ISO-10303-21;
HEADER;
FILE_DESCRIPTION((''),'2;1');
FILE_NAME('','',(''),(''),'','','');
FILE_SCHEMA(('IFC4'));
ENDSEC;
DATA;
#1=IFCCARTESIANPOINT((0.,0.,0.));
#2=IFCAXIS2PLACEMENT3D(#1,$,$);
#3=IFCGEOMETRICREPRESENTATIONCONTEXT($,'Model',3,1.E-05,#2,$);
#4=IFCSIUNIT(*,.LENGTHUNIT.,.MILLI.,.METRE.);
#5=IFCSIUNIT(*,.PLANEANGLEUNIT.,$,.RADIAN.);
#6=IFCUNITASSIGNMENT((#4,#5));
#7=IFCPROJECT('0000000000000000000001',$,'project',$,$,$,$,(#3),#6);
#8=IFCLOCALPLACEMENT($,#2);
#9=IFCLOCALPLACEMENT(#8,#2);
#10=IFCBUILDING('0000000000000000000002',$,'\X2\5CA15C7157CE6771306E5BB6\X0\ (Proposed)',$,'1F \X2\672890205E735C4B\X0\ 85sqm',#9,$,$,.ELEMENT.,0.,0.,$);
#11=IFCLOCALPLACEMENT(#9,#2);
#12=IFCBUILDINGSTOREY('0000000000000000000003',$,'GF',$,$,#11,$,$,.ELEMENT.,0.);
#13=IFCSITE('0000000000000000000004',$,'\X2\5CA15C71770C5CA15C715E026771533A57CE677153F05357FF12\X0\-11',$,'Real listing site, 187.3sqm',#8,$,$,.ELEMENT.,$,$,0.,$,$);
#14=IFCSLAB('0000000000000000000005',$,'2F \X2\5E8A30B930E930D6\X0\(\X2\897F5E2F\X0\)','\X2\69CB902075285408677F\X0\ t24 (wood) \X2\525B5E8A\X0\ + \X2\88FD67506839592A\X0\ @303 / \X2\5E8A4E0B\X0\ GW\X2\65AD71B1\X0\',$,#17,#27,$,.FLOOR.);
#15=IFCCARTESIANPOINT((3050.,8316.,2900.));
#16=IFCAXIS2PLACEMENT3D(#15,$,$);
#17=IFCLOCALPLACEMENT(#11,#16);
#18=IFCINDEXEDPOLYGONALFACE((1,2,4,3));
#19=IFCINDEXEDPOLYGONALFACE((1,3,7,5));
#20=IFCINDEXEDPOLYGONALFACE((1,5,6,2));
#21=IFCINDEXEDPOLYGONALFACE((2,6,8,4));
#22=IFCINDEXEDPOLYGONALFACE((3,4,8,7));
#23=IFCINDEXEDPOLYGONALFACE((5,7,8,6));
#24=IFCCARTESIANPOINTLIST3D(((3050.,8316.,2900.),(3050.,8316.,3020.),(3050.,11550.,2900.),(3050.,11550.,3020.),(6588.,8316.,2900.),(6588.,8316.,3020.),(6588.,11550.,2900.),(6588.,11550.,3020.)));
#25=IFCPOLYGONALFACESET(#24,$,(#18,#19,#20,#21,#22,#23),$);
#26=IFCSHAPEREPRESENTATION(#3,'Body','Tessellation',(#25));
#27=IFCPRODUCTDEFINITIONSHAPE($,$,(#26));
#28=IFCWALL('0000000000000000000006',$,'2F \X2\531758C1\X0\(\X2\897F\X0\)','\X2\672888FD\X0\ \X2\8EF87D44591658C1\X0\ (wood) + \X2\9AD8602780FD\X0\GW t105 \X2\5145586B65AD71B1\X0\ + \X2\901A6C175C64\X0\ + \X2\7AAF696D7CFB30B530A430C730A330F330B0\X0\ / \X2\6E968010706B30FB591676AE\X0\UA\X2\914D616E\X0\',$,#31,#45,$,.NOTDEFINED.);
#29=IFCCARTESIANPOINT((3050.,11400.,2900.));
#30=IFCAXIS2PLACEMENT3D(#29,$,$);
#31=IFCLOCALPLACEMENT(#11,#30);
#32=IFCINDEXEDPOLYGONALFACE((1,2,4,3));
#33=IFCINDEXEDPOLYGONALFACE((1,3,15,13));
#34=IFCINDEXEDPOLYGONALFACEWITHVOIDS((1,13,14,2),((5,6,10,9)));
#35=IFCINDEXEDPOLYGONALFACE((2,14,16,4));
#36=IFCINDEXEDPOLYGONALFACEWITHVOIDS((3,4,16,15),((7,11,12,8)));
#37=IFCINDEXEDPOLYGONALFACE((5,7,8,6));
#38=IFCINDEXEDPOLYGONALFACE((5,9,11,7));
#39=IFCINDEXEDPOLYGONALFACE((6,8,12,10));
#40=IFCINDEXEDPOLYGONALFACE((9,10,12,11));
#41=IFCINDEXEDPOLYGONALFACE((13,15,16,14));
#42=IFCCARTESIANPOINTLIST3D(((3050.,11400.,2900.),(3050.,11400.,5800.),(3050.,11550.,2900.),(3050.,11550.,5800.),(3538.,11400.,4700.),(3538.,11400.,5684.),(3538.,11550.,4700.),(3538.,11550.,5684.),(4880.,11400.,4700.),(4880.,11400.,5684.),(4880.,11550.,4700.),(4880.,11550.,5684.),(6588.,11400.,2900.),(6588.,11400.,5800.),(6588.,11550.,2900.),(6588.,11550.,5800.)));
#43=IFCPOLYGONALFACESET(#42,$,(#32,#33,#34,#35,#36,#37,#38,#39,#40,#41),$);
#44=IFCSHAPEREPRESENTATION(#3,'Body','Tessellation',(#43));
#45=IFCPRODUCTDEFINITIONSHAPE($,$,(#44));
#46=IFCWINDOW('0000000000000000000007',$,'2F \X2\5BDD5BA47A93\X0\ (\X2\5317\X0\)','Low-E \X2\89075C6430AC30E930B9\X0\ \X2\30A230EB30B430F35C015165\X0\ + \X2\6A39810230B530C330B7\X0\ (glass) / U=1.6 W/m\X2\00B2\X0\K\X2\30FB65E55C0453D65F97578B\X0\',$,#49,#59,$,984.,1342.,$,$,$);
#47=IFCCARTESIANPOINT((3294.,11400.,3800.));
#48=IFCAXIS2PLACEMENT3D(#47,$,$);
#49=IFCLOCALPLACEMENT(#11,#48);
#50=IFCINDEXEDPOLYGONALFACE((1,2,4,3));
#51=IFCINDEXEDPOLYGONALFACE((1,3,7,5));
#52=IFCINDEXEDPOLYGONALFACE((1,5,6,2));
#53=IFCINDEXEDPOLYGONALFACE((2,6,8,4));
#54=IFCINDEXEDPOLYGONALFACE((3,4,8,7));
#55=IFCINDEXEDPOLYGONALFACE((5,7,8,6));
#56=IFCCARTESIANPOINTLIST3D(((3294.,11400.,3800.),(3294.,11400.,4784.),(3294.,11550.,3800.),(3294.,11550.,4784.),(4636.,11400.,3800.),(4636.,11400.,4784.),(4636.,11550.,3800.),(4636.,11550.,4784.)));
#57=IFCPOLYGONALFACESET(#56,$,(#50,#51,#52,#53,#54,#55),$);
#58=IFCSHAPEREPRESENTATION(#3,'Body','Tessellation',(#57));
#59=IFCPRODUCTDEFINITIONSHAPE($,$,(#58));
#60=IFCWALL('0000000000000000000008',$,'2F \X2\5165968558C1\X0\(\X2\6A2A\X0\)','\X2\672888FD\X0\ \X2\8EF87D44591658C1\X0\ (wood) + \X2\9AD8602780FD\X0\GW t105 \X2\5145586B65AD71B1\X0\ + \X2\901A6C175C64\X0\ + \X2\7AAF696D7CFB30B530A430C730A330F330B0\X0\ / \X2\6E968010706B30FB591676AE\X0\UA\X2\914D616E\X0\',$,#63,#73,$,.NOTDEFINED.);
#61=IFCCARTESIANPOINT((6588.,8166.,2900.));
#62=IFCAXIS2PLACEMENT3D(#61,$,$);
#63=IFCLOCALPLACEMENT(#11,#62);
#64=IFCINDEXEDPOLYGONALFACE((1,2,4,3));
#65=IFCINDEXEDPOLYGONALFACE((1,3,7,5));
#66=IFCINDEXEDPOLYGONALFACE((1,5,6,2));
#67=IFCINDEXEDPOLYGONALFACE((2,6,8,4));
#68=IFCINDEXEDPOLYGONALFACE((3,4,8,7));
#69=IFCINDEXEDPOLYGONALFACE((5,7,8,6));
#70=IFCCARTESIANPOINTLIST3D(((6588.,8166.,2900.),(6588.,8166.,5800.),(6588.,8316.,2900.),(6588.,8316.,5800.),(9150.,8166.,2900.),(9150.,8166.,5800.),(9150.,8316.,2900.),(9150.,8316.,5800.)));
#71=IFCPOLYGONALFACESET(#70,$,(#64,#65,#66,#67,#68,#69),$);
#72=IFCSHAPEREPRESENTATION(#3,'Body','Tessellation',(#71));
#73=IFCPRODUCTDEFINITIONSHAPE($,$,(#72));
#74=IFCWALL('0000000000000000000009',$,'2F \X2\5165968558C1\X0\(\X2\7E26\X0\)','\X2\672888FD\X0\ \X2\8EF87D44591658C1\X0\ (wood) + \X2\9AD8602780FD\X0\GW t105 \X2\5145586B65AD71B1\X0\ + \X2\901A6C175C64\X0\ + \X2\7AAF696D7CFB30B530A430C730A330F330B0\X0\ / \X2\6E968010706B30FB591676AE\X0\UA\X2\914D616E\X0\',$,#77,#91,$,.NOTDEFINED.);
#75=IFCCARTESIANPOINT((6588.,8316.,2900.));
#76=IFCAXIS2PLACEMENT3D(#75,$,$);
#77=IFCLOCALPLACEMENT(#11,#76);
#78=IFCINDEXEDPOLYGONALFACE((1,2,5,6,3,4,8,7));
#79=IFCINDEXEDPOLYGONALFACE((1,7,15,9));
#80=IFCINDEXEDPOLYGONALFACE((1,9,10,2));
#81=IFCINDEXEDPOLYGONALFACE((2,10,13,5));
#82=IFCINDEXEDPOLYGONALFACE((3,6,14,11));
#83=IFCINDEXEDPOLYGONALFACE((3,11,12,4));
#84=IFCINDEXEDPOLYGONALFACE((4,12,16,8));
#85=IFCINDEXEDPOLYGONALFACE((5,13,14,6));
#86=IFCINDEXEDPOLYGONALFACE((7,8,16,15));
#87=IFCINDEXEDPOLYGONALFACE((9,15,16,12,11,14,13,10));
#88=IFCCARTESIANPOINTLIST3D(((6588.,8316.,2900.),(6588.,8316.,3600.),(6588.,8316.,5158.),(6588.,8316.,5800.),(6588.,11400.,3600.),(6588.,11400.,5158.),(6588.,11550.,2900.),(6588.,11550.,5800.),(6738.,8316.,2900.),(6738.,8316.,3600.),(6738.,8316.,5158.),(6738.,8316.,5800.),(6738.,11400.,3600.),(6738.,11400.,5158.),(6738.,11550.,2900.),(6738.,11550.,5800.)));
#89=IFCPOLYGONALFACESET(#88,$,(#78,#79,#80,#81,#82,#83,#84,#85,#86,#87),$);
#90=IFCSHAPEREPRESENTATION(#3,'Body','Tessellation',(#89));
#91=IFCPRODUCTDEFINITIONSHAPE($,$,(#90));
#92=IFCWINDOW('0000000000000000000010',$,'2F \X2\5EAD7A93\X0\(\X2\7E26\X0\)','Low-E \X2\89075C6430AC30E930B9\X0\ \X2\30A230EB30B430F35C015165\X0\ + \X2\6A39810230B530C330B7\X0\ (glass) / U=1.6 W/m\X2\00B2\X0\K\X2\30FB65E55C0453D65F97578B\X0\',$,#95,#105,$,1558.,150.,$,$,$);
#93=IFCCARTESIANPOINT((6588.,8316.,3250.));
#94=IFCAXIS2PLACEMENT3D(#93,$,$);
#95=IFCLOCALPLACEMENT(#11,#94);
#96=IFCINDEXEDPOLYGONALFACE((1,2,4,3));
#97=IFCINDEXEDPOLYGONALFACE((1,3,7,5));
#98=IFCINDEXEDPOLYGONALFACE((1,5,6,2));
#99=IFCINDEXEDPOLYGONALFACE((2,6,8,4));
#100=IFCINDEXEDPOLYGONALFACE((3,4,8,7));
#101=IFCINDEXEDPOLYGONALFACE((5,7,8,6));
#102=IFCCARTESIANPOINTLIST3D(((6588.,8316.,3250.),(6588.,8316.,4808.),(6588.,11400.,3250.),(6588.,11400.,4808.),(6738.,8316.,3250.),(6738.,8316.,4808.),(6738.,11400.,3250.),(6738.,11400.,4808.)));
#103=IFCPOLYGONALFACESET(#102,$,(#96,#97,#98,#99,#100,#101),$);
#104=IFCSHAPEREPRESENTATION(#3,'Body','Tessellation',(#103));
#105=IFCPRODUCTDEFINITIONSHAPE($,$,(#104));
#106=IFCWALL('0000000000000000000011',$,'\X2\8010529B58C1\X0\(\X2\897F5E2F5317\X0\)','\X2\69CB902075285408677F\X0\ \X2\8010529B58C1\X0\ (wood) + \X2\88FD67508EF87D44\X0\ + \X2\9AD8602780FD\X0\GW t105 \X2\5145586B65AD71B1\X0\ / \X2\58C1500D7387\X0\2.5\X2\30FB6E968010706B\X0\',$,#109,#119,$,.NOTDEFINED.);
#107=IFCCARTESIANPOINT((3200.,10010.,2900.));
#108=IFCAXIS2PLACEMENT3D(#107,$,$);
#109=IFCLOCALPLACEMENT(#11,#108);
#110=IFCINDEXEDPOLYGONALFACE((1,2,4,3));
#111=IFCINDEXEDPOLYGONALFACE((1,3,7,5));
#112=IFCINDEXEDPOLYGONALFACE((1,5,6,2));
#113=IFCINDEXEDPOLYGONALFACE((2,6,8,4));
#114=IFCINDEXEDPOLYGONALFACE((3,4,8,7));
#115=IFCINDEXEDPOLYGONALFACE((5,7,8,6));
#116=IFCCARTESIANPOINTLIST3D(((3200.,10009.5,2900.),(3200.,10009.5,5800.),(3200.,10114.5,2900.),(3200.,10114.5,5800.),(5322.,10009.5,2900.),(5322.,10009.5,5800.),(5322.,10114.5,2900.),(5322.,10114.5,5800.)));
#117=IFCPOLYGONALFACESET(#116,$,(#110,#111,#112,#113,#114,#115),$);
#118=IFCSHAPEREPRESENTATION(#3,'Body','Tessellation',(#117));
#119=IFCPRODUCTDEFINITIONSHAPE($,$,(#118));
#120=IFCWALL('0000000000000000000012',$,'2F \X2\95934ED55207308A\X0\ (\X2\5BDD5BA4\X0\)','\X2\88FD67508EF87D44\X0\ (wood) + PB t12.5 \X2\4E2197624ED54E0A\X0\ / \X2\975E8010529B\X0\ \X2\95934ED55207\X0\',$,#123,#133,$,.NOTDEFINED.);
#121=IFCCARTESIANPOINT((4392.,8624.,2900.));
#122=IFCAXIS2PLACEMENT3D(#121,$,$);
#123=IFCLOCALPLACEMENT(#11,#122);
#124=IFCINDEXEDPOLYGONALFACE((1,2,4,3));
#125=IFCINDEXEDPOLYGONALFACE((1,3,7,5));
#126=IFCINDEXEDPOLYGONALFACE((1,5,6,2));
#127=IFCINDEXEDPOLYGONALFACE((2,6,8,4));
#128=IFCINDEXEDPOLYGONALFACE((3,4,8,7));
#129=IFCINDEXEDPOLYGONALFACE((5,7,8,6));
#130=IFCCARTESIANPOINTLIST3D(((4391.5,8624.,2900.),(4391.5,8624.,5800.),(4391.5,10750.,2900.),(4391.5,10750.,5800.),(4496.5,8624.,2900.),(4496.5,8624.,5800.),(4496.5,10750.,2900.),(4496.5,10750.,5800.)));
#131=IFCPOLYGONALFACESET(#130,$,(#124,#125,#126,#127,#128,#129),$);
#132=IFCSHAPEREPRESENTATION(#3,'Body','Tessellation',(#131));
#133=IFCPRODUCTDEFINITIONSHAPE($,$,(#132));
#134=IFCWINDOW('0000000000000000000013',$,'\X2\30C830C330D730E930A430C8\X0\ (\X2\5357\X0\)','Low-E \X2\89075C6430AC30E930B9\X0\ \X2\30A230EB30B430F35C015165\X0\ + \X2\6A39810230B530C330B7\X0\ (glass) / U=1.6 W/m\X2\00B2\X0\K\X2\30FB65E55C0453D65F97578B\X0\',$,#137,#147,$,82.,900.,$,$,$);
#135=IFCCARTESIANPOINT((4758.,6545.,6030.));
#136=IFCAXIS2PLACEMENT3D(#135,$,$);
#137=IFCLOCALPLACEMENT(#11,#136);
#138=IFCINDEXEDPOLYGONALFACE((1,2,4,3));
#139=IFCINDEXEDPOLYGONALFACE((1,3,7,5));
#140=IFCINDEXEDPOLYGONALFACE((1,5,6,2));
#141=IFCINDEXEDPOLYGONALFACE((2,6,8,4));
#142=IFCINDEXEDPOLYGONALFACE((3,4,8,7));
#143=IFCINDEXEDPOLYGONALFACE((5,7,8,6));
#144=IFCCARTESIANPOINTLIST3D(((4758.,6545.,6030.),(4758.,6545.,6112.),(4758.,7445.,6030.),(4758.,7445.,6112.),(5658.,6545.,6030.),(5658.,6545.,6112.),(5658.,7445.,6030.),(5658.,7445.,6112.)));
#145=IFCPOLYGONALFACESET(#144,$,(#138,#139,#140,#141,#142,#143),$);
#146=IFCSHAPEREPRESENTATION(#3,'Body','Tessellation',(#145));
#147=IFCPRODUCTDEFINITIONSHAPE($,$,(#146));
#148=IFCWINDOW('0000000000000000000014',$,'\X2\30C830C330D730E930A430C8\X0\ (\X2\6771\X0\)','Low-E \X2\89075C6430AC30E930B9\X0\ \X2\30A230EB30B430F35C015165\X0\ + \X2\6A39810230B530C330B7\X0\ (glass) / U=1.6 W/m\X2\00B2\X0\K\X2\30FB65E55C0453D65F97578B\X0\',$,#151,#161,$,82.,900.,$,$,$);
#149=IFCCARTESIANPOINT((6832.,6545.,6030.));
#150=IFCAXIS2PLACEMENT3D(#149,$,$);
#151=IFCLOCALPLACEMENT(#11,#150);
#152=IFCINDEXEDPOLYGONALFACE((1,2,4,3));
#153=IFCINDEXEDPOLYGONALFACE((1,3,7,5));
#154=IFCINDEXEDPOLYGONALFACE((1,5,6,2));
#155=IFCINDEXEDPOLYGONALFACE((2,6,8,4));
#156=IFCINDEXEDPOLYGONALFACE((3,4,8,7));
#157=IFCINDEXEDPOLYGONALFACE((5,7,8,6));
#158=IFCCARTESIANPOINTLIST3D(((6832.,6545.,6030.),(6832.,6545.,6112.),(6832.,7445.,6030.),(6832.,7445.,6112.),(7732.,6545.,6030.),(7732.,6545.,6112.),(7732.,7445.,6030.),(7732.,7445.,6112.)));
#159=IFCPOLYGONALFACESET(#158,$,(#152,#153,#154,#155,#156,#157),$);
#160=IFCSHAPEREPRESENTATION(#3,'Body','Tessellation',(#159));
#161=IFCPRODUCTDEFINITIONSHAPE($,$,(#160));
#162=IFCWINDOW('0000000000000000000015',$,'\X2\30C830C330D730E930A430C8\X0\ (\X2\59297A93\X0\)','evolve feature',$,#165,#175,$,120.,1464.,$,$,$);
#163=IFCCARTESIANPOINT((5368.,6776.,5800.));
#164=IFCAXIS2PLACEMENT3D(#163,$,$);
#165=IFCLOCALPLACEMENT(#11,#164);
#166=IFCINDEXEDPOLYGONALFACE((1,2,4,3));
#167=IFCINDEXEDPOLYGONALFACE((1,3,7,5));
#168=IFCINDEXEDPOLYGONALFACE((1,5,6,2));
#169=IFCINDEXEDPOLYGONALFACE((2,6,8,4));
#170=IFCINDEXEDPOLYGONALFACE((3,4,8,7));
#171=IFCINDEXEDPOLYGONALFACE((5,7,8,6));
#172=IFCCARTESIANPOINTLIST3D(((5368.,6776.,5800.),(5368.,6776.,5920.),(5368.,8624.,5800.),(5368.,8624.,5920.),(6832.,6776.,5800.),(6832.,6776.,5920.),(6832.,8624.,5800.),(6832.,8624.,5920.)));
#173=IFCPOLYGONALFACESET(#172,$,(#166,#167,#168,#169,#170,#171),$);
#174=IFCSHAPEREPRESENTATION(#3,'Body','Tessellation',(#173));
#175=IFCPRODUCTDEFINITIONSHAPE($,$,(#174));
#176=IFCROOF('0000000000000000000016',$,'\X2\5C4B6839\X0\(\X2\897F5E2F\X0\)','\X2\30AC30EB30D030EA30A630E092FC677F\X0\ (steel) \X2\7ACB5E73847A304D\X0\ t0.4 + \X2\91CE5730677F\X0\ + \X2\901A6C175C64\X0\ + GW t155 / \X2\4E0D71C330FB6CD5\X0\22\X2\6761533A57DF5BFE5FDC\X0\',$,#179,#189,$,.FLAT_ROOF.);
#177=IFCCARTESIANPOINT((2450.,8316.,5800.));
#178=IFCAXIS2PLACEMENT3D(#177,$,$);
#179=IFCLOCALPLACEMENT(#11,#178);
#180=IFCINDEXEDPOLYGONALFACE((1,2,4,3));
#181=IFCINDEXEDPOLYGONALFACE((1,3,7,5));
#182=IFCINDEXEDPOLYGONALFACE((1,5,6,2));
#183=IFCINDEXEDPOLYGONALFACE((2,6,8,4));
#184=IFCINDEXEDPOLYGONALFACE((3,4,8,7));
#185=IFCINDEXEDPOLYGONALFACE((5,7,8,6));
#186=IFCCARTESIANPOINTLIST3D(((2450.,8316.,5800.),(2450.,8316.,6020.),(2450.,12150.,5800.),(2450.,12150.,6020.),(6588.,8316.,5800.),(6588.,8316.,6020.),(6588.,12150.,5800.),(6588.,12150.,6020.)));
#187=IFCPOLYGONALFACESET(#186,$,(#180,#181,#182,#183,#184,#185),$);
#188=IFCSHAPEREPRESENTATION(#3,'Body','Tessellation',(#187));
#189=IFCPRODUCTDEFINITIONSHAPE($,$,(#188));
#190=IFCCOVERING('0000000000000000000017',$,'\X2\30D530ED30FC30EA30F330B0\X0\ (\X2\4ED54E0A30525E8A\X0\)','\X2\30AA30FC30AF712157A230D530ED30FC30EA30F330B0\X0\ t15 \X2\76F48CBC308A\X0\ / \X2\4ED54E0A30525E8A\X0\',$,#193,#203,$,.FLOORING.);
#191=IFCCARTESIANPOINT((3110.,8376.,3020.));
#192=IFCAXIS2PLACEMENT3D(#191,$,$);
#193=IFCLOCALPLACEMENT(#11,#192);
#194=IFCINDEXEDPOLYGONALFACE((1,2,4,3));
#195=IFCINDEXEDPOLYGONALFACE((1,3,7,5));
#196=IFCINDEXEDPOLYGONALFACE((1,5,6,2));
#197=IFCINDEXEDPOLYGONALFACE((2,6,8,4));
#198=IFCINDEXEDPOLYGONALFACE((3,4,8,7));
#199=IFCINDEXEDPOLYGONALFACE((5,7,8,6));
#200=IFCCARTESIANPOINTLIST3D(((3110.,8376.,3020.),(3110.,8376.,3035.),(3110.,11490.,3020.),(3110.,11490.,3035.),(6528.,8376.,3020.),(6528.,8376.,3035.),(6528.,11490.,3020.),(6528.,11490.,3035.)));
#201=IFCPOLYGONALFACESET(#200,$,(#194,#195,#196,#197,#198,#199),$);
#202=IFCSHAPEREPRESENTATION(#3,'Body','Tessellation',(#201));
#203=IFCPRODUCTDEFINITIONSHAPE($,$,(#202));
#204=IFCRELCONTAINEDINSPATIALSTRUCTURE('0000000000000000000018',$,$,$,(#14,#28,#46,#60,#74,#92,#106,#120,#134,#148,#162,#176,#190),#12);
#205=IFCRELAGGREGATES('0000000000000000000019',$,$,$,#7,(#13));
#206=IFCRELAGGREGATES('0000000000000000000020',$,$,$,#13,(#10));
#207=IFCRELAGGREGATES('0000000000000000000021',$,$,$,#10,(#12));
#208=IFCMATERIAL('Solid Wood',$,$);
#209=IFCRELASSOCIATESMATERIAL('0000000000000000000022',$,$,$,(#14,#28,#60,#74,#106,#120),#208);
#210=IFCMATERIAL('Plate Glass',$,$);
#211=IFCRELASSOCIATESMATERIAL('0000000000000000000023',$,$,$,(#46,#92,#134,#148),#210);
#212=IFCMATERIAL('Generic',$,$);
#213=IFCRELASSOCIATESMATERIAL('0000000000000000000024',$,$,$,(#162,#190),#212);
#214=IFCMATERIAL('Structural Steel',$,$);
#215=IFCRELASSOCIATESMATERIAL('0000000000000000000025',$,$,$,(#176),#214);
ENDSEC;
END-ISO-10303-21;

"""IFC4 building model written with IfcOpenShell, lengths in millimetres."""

from ifc_helpers import new_model, si_unit, frame, frame_2d, origin, place, context, project, spatial, rectangle, extrude, material, element, fill, save


model = new_model("IFC4")

# Units and contexts
model_context = context("Model", 3, precision=1e-05, world=origin())
ifc_project = project(units=[si_unit("LENGTHUNIT", "METRE", prefix="MILLI"), si_unit("PLANEANGLEUNIT", "RADIAN")], contexts=[model_context])

# Site, building, storey
site_placement = place(None, origin())
site = spatial("IfcSite", under=ifc_project, at=site_placement, Name="岡山県岡山市東区城東台南２-11", ObjectType="Real listing site, 187.3sqm", CompositionType="ELEMENT", RefElevation=0.0)
building_placement = place(site_placement, origin())
building = spatial("IfcBuilding", under=site, at=building_placement, Name="岡山城東の家 (Proposed)", ObjectType="1F 木造平屋 85sqm", CompositionType="ELEMENT", ElevationOfRefHeight=0.0, ElevationOfTerrain=0.0)
storey_placement = place(building_placement, origin())
storey = spatial("IfcBuildingStorey", under=building, at=storey_placement, Name="GF", CompositionType="ELEMENT", Elevation=0.0)

# Slab
ifc_material_1 = material(Name="Solid Wood")
slab_placement = place(storey_placement, frame((3050.0, 8316.0, 2900.0)))
element("IfcSlab", 1, at=slab_placement, inside=storey, material=ifc_material_1, Name="2F 床スラブ(西帯)", Description="構造用合板 t24 (wood) 剛床 + 製材根太 @303 / 床下 GW断熱", PredefinedType="FLOOR", context=model_context, shape_type="SweptSolid", body=[
    extrude(rectangle(XDim=3538.0, YDim=3234.0, at=frame_2d((1769.0, 1617.0))), frame((3050.0, 8316.0, 2900.0)), (0.0, 0.0, 1.0), 120.0),
])

# Wall, opening, window
wall_1_placement = place(storey_placement, frame((3050.0, 11400.0, 2900.0)))
wall_1 = element("IfcWall", 2, at=wall_1_placement, inside=storey, material=ifc_material_1, Name="2F 北壁(西)", Description="木製 軸組外壁 (wood) + 高性能GW t105 充填断熱 + 通気層 + 窯業系サイディング / 準耐火・外皮UA配慮", PredefinedType="NOTDEFINED", context=model_context, shape_type="SweptSolid", body=[
    extrude(rectangle(XDim=3538.0, YDim=150.0, at=frame_2d((1769.0, 75.0))), frame((3050.0, 11400.0, 2900.0)), (0.0, 0.0, 1.0), 2900.0),
])
opening_1_placement = place(storey_placement, frame((3294.0, 11400.0, 3800.0)))
opening_1 = element("IfcOpeningElement", 3, at=opening_1_placement, cuts=wall_1, PredefinedType="NOTDEFINED", context=model_context, shape_type="SweptSolid", body=[
    extrude(rectangle(XDim=1342.0, YDim=150.0, at=frame_2d((671.0, 75.0))), frame((3294.0, 11400.0, 3800.0)), (0.0, 0.0, 1.0), 984.0),
])
ifc_material_2 = material(Name="Plate Glass")
window_1_placement = place(storey_placement, frame((3294.0, 11400.0, 3800.0)))
window_1 = element("IfcWindow", 4, at=window_1_placement, inside=storey, material=ifc_material_2, Name="2F 寝室窓 (北)", Description="Low-E 複層ガラス アルゴン封入 + 樹脂サッシ (glass) / U=1.6 W/m²K・日射取得型", OverallHeight=984.0, OverallWidth=1342.0, context=model_context, shape_type="SweptSolid", body=[
    extrude(rectangle(XDim=1342.0, YDim=150.0, at=frame_2d((671.0, 75.0))), frame((3294.0, 11400.0, 3800.0)), (0.0, 0.0, 1.0), 984.0),
])
fill(opening_1, window_1)

# Wall
wall_2_placement = place(storey_placement, frame((6588.0, 8166.0, 2900.0)))
element("IfcWall", 5, at=wall_2_placement, inside=storey, material=ifc_material_1, Name="2F 入隅壁(横)", Description="木製 軸組外壁 (wood) + 高性能GW t105 充填断熱 + 通気層 + 窯業系サイディング / 準耐火・外皮UA配慮", PredefinedType="NOTDEFINED", context=model_context, shape_type="SweptSolid", body=[
    extrude(rectangle(XDim=2562.0, YDim=150.0, at=frame_2d((1281.0, 75.0))), frame((6588.0, 8166.0, 2900.0)), (0.0, 0.0, 1.0), 2900.0),
])

# Wall, opening, window
wall_3_placement = place(storey_placement, frame((6588.0, 8316.0, 2900.0)))
wall_3 = element("IfcWall", 6, at=wall_3_placement, inside=storey, material=ifc_material_1, Name="2F 入隅壁(縦)", Description="木製 軸組外壁 (wood) + 高性能GW t105 充填断熱 + 通気層 + 窯業系サイディング / 準耐火・外皮UA配慮", PredefinedType="NOTDEFINED", context=model_context, shape_type="SweptSolid", body=[
    extrude(rectangle(XDim=150.0, YDim=3234.0, at=frame_2d((75.0, 1617.0))), frame((6588.0, 8316.0, 2900.0)), (0.0, 0.0, 1.0), 2900.0),
])
opening_2_placement = place(storey_placement, frame((6588.0, 8316.0, 3250.0)))
opening_2 = element("IfcOpeningElement", 7, at=opening_2_placement, cuts=wall_3, PredefinedType="NOTDEFINED", context=model_context, shape_type="SweptSolid", body=[
    extrude(rectangle(XDim=150.0, YDim=3084.0, at=frame_2d((75.0, 1542.0))), frame((6588.0, 8316.0, 3250.0)), (0.0, 0.0, 1.0), 1558.0),
])
window_2_placement = place(storey_placement, frame((6588.0, 8316.0, 3250.0)))
window_2 = element("IfcWindow", 8, at=window_2_placement, inside=storey, material=ifc_material_2, Name="2F 庭窓(縦)", Description="Low-E 複層ガラス アルゴン封入 + 樹脂サッシ (glass) / U=1.6 W/m²K・日射取得型", OverallHeight=1558.0, OverallWidth=150.0, context=model_context, shape_type="SweptSolid", body=[
    extrude(rectangle(XDim=150.0, YDim=3084.0, at=frame_2d((75.0, 1542.0))), frame((6588.0, 8316.0, 3250.0)), (0.0, 0.0, 1.0), 1558.0),
])
fill(opening_2, window_2)

# Walls
wall_4_placement = place(storey_placement, frame((3200.0, 10010.0, 2900.0)))
element("IfcWall", 9, at=wall_4_placement, inside=storey, material=ifc_material_1, Name="耐力壁(西帯北)", Description="構造用合板 耐力壁 (wood) + 製材軸組 + 高性能GW t105 充填断熱 / 壁倍率2.5・準耐火", PredefinedType="NOTDEFINED", context=model_context, shape_type="SweptSolid", body=[
    extrude(rectangle(XDim=2122.0, YDim=105.0, at=frame_2d((1061.0, 52.0))), frame((3200.0, 10010.0, 2900.0)), (0.0, 0.0, 1.0), 2900.0),
])
wall_5_placement = place(storey_placement, frame((4392.0, 8624.0, 2900.0)))
element("IfcWall", 10, at=wall_5_placement, inside=storey, material=ifc_material_1, Name="2F 間仕切り (寝室)", Description="製材軸組 (wood) + PB t12.5 両面仕上 / 非耐力 間仕切", PredefinedType="NOTDEFINED", context=model_context, shape_type="SweptSolid", body=[
    extrude(rectangle(XDim=105.0, YDim=2126.0, at=frame_2d((52.0, 1063.0))), frame((4392.0, 8624.0, 2900.0)), (0.0, 0.0, 1.0), 2900.0),
])

# Windows
window_3_placement = place(storey_placement, frame((4758.0, 6545.0, 6030.0)))
element("IfcWindow", 11, at=window_3_placement, inside=storey, material=ifc_material_2, Name="トップライト (南)", Description="Low-E 複層ガラス アルゴン封入 + 樹脂サッシ (glass) / U=1.6 W/m²K・日射取得型", OverallHeight=82.0, OverallWidth=900.0, context=model_context, shape_type="SweptSolid", body=[
    extrude(rectangle(XDim=900.0, YDim=900.0, at=frame_2d((450.0, 450.0))), frame((4758.0, 6545.0, 6030.0)), (0.0, 0.0, 1.0), 82.0),
])
window_4_placement = place(storey_placement, frame((6832.0, 6545.0, 6030.0)))
element("IfcWindow", 12, at=window_4_placement, inside=storey, material=ifc_material_2, Name="トップライト (東)", Description="Low-E 複層ガラス アルゴン封入 + 樹脂サッシ (glass) / U=1.6 W/m²K・日射取得型", OverallHeight=82.0, OverallWidth=900.0, context=model_context, shape_type="SweptSolid", body=[
    extrude(rectangle(XDim=900.0, YDim=900.0, at=frame_2d((450.0, 450.0))), frame((6832.0, 6545.0, 6030.0)), (0.0, 0.0, 1.0), 82.0),
])
ifc_material_3 = material(Name="Generic")
window_5_placement = place(storey_placement, frame((5368.0, 6776.0, 5800.0)))
element("IfcWindow", 13, at=window_5_placement, inside=storey, material=ifc_material_3, Name="トップライト (天窓)", Description="evolve feature", OverallHeight=120.0, OverallWidth=1464.0, context=model_context, shape_type="SweptSolid", body=[
    extrude(rectangle(XDim=1464.0, YDim=1848.0, at=frame_2d((732.0, 924.0))), frame((5368.0, 6776.0, 5800.0)), (0.0, 0.0, 1.0), 120.0),
])

# Roof
ifc_material_4 = material(Name="Structural Steel")
for number, where, name in (
    (14, (2450.0, 8316.0, 5800.0), "屋根(西帯)"),
):
    element("IfcRoof", number, at=place(storey_placement, frame(where)), inside=storey, material=ifc_material_4, Name=name, Description="ガルバリウム鋼板 (steel) 立平葺き t0.4 + 野地板 + 通気層 + GW t155 / 不燃・法22条区域対応", PredefinedType="FLAT_ROOF", context=model_context, shape_type="SweptSolid", body=[
        extrude(rectangle(XDim=4138.0, YDim=3834.0, at=frame_2d((2069.0, 1917.0))), frame((2450.0, 8316.0, 5800.0)), (0.0, 0.0, 1.0), 220.0),
    ])

# Covering
covering_placement = place(storey_placement, frame((3110.0, 8376.0, 3020.0)))
element("IfcCovering", 15, at=covering_placement, inside=storey, material=ifc_material_3, Name="フローリング (仕上げ床)", Description="オーク無垢フローリング t15 直貼り / 仕上げ床", PredefinedType="FLOORING", context=model_context, shape_type="SweptSolid", body=[
    extrude(rectangle(XDim=3418.0, YDim=3114.0, at=frame_2d((1709.0, 1557.0))), frame((3110.0, 8376.0, 3020.0)), (0.0, 0.0, 1.0), 15.0),
])

save(model, "model.ifc")
